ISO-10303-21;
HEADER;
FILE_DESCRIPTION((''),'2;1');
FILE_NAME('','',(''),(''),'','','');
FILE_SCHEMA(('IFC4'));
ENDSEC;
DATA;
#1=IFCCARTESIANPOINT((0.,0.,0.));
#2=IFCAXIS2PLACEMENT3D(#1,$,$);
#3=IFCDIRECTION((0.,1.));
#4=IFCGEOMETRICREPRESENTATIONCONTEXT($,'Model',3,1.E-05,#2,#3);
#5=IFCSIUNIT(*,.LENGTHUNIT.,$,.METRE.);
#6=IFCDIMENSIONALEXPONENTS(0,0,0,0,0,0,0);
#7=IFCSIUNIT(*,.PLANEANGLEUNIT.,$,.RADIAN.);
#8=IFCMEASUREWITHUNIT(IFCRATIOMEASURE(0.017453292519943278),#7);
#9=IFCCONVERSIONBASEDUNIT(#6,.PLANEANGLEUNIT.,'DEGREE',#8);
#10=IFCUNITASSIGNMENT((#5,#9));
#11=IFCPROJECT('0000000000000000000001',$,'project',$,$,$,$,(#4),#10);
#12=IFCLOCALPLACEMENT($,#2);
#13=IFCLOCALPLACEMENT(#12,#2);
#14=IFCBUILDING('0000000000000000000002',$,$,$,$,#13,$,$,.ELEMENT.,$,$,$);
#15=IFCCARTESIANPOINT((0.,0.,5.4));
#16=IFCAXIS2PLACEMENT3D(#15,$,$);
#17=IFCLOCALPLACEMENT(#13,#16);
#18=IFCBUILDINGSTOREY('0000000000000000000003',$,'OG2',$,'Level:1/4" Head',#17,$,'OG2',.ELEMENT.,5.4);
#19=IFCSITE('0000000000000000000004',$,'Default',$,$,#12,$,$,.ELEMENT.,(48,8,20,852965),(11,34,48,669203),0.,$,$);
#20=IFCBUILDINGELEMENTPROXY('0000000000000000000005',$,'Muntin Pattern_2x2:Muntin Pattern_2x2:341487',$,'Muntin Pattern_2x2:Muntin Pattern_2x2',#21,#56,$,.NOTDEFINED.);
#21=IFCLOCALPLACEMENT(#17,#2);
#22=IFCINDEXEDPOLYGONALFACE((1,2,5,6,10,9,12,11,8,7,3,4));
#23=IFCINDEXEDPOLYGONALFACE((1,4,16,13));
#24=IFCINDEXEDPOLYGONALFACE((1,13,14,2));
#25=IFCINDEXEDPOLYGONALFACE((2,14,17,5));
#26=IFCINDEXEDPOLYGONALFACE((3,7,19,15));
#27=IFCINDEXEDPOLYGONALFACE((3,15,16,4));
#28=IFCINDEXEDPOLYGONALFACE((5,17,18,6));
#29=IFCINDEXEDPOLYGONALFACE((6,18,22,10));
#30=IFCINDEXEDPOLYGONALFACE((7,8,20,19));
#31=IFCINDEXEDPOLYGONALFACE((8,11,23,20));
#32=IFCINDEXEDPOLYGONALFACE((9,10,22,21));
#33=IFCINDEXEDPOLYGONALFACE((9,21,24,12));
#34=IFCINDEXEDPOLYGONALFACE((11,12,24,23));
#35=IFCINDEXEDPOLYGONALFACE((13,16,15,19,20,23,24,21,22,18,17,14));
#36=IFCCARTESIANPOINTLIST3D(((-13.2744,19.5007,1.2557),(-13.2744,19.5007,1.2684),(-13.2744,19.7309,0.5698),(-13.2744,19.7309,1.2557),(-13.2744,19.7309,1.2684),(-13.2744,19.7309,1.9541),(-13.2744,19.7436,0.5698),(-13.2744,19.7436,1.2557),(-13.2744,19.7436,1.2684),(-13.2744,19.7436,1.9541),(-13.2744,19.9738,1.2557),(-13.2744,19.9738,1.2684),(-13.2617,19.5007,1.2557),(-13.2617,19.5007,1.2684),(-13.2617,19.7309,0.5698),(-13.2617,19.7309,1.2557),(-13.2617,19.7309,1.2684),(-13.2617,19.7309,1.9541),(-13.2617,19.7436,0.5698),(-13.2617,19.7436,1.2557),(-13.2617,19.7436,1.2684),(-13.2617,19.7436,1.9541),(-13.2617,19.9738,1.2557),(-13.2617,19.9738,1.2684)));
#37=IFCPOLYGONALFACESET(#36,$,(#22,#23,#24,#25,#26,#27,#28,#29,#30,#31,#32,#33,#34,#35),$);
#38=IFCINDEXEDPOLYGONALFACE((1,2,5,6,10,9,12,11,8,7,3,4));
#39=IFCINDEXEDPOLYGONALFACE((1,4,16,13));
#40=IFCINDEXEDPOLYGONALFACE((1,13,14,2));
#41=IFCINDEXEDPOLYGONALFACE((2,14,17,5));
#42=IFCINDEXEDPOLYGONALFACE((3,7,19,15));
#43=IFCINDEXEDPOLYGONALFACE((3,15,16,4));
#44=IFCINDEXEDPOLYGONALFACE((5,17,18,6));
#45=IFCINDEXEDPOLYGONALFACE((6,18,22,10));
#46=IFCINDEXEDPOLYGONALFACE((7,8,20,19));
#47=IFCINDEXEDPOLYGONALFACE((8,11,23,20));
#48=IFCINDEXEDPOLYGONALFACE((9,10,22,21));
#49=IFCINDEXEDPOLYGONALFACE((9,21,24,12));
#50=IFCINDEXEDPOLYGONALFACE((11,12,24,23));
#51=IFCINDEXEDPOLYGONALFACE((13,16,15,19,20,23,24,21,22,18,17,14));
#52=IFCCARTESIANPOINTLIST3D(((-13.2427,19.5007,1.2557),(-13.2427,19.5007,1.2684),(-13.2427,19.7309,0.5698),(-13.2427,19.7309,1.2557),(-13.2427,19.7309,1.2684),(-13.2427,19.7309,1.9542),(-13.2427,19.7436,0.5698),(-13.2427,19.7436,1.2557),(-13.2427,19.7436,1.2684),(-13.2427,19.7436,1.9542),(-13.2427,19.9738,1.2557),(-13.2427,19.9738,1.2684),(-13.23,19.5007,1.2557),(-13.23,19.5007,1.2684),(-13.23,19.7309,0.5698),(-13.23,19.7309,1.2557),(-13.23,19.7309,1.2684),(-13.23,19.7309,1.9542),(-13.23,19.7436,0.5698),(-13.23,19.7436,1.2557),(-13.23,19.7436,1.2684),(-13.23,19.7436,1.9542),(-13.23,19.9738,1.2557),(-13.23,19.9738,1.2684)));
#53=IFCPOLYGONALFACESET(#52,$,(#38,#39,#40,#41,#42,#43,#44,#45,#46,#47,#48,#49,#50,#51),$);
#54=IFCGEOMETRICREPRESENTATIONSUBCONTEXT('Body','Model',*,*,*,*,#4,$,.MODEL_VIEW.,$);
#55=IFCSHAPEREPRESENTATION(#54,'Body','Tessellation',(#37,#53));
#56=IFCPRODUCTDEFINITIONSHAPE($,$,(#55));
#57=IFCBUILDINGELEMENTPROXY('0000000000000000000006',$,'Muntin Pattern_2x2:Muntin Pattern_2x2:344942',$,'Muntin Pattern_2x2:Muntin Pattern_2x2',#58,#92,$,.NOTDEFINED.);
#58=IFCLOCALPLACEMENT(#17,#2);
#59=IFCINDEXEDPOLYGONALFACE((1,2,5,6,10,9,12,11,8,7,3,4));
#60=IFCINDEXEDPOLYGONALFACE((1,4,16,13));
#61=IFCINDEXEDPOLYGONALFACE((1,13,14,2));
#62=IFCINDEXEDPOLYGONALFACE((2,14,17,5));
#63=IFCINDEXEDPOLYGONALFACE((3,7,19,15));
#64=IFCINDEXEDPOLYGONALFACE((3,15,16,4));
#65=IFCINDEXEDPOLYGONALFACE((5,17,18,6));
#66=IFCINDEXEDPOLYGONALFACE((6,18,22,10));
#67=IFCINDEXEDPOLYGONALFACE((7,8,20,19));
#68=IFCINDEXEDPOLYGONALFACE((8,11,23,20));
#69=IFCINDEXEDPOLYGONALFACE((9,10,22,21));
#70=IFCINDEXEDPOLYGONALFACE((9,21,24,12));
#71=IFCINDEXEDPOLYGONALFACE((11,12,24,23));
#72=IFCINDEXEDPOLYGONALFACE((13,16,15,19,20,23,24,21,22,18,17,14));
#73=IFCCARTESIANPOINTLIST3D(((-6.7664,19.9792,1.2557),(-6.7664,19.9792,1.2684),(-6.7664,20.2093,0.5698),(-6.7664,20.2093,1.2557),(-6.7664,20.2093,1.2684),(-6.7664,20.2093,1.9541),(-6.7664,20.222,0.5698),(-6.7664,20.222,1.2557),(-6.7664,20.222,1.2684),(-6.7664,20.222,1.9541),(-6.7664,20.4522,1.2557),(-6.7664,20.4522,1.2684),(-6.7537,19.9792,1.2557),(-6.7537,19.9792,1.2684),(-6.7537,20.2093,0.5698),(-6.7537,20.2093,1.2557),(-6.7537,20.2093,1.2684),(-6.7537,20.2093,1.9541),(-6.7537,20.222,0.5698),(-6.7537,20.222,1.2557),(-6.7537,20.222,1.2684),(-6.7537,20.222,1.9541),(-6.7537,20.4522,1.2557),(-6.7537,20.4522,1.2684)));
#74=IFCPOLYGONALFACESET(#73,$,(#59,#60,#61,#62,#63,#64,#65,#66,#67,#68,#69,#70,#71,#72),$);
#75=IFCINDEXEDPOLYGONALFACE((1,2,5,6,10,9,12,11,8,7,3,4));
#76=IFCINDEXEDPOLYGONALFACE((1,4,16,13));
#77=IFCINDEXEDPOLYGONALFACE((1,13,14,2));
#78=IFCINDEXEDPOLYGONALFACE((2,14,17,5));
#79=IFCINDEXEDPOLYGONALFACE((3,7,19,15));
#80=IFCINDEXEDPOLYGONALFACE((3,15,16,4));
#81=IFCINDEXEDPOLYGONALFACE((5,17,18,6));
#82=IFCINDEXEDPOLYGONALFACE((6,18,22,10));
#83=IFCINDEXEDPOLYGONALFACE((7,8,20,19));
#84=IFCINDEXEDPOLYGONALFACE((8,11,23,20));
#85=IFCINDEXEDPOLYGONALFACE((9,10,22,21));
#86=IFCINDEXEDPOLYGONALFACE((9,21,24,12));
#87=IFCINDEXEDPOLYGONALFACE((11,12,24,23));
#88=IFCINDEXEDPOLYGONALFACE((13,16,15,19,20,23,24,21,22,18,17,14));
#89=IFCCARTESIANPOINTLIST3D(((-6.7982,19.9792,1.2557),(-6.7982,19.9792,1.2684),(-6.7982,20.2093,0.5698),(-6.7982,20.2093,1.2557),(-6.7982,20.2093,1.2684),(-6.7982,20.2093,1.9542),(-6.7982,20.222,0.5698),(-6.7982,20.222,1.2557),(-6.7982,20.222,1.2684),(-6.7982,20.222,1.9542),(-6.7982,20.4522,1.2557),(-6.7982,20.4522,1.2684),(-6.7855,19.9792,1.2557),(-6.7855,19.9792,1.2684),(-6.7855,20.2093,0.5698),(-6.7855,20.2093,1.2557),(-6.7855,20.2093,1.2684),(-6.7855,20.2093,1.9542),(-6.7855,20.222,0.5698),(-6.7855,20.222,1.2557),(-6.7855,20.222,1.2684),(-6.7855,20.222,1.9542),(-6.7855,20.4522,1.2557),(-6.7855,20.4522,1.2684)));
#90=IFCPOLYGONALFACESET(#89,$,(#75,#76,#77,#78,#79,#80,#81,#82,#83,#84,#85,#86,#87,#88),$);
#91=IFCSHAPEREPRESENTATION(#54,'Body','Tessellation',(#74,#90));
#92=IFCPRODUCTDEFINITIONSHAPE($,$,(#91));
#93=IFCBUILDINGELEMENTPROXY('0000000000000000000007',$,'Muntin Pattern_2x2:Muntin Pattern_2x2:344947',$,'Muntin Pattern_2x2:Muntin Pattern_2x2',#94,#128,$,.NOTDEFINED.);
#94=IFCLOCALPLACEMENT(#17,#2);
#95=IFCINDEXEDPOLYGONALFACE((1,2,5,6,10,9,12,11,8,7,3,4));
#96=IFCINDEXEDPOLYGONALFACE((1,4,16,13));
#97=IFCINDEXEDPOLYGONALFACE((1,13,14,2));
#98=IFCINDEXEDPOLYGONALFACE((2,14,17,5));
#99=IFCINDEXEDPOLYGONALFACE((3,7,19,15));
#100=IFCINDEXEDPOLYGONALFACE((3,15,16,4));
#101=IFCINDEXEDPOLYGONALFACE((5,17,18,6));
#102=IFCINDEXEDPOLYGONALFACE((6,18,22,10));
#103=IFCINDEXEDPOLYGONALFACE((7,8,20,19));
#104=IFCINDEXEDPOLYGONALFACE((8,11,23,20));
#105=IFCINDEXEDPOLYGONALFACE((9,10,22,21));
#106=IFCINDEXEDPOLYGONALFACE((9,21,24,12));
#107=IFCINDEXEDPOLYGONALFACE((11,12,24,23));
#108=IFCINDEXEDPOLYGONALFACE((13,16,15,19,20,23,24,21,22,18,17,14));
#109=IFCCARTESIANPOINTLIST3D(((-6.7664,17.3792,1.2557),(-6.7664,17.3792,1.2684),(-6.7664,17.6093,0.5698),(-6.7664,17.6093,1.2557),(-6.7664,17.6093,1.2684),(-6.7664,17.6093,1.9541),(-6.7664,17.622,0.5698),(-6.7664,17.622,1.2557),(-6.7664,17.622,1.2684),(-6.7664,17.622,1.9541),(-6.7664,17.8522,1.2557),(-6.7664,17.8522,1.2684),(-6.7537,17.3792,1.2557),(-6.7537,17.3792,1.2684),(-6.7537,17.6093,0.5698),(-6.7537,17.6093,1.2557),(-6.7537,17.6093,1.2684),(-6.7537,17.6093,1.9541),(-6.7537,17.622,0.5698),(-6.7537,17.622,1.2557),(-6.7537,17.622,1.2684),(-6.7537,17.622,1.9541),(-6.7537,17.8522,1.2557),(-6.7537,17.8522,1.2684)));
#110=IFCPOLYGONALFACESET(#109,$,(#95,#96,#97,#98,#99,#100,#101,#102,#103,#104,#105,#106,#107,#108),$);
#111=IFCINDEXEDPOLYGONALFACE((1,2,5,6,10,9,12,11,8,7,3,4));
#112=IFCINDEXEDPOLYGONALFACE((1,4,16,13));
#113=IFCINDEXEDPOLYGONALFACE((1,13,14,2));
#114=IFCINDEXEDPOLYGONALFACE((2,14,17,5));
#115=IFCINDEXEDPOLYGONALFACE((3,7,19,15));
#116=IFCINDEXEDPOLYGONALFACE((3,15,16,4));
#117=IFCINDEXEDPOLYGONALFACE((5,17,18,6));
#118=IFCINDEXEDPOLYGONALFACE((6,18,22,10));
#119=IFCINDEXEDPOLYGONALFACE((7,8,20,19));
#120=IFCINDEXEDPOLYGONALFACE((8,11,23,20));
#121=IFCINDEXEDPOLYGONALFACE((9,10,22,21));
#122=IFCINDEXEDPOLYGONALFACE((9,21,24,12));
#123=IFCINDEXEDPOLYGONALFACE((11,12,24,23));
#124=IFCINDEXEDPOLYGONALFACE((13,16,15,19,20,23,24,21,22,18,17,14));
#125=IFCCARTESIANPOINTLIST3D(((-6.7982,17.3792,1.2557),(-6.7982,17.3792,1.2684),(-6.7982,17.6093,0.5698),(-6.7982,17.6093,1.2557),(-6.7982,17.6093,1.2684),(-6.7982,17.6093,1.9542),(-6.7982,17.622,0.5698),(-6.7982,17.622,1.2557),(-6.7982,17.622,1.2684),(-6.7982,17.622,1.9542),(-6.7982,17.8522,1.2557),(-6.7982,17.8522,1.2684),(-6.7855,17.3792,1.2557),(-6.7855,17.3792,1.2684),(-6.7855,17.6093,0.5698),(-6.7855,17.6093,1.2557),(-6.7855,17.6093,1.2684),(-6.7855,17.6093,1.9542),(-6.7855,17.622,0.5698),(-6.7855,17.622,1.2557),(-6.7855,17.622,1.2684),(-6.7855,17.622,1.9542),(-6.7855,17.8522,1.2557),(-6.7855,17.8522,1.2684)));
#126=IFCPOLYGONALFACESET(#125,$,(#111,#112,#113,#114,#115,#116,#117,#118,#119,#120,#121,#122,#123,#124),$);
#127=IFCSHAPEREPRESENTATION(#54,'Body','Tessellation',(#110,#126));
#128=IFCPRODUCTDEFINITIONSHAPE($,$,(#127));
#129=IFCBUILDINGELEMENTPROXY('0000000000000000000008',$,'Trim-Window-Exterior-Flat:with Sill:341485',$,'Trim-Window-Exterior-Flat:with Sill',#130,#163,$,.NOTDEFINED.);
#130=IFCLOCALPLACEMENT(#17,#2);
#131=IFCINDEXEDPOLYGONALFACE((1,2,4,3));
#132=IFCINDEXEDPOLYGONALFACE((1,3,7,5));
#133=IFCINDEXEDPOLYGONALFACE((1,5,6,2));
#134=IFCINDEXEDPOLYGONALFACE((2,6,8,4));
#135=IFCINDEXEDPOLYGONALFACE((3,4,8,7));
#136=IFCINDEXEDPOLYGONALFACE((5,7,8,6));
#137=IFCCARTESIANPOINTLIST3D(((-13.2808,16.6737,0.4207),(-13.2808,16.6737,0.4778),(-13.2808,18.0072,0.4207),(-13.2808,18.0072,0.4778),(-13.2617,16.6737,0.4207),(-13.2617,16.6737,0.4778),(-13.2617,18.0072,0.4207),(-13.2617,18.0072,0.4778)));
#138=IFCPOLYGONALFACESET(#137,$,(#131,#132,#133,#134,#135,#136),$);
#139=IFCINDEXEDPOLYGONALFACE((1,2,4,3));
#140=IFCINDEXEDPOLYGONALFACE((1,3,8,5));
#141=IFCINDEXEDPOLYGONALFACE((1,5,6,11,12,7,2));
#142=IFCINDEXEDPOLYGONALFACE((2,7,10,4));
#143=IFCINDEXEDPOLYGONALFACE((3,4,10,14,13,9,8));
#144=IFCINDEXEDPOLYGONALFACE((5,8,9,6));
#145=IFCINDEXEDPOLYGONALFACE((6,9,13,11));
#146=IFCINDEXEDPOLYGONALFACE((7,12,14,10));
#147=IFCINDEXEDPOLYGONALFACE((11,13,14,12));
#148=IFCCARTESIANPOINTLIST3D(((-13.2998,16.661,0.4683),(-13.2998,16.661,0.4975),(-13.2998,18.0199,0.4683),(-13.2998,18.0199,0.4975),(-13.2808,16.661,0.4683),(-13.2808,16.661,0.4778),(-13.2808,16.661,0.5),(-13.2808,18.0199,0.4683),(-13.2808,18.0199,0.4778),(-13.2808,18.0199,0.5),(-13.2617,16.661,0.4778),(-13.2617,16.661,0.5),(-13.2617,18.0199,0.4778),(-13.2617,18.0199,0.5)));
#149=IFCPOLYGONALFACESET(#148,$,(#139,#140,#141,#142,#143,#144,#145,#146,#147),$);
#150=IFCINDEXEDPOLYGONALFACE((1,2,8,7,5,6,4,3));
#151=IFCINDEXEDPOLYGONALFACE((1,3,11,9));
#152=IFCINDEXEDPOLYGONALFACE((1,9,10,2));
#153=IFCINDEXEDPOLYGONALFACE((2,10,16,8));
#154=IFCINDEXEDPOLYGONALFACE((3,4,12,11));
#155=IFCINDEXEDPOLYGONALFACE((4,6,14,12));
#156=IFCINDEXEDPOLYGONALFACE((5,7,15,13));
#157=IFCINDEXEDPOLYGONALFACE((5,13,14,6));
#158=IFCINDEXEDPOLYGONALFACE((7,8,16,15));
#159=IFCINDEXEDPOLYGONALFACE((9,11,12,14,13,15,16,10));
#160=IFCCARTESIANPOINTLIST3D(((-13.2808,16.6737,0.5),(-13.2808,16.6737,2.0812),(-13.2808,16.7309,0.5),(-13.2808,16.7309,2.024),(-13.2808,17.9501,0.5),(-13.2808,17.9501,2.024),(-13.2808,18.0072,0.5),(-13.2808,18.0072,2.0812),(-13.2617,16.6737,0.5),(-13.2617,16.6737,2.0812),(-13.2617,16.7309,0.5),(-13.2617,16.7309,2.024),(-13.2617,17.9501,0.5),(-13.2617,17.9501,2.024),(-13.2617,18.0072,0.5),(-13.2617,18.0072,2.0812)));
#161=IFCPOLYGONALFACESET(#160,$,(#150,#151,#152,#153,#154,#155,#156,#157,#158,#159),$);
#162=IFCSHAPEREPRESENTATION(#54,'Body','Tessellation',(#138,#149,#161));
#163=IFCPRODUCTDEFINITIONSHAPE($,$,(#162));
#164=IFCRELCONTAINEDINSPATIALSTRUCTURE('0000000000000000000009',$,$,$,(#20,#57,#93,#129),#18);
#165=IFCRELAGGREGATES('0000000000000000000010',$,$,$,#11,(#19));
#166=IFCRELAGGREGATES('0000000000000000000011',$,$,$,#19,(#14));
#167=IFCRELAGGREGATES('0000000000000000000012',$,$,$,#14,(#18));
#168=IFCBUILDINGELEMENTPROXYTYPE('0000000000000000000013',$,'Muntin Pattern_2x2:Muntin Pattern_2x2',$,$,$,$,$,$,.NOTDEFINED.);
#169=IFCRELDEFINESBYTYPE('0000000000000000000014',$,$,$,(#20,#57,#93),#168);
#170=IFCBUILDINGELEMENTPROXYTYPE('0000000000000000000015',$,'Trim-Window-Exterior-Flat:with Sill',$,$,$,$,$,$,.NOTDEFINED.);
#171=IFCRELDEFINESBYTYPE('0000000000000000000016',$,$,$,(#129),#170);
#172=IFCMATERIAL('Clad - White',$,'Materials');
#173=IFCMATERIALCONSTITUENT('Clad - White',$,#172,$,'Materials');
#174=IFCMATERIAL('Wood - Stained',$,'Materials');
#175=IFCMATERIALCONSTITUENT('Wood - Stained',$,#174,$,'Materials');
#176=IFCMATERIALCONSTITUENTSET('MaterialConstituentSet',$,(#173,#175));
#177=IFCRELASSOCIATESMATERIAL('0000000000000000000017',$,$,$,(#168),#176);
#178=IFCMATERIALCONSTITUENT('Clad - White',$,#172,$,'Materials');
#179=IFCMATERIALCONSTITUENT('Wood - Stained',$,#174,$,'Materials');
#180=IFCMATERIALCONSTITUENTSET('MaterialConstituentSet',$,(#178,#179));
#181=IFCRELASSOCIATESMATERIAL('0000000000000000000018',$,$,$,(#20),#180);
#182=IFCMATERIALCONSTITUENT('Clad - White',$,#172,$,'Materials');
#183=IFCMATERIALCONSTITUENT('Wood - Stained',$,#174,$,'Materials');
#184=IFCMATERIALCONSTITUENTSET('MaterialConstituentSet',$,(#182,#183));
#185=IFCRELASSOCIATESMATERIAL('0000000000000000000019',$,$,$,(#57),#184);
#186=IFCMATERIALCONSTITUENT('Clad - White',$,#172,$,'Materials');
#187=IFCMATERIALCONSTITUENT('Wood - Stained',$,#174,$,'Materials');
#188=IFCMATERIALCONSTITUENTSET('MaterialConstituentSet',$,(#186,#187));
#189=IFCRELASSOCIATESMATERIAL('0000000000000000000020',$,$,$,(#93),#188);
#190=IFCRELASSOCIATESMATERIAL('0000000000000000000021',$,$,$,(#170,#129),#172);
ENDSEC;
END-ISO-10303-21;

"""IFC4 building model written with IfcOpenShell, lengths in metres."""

from ifc_helpers import new_model, entity, si_unit, converted_unit, direction, frame, origin, place, context, subcontext, project, spatial, indexed_curve, outline, extrude, source, transform, mapped, material, constituent, constituent_set, type_object, type_shapes, element, save


model = new_model("IFC4")

# Units and contexts
model_context = context("Model", 3, precision=1e-05, world=origin(), true_north=direction((0.0, 1.0)))
body_context = subcontext(model_context, "Body", "Model", "MODEL_VIEW")
ifc_project = project(units=[si_unit("LENGTHUNIT", "METRE"), converted_unit("PLANEANGLEUNIT", "DEGREE", entity("IfcRatioMeasure", 0.017453292519943278), si_unit("PLANEANGLEUNIT", "RADIAN"), dimensions=[0, 0, 0, 0, 0, 0, 0])], contexts=[model_context])

# Site, building, storey
site_placement = place(None, origin())
site = spatial("IfcSite", under=ifc_project, at=site_placement, Name="Default", CompositionType="ELEMENT", RefLatitude=(48, 8, 20, 852965), RefLongitude=(11, 34, 48, 669203), RefElevation=0.0)
building_placement = place(site_placement, origin())
building = spatial("IfcBuilding", under=site, at=building_placement, CompositionType="ELEMENT")
storey_placement = place(building_placement, frame((0.0, 0.0, 5.4)))
storey = spatial("IfcBuildingStorey", under=building, at=storey_placement, Name="OG2", ObjectType="Level:1/4\" Head", LongName="OG2", CompositionType="ELEMENT", Elevation=5.4)

# Building element proxies
ifc_material_1 = material(Name="Clad - White", Category="Materials")
ifc_material_2 = material(Name="Wood - Stained", Category="Materials")
ifc_constituent_1 = constituent(ifc_material_1, Name="Clad - White", Category="Materials")
ifc_constituent_2 = constituent(ifc_material_2, Name="Wood - Stained", Category="Materials")
ifc_constituent_set_1 = constituent_set(constituents=[ifc_constituent_1, ifc_constituent_2], Name="MaterialConstituentSet")
building_element_proxy_type_1 = type_object("IfcBuildingElementProxyType", Name="Muntin Pattern_2x2:Muntin Pattern_2x2", PredefinedType="NOTDEFINED", material=ifc_constituent_set_1)
shared_shape_1 = source(origin(), body_context, "Body", "SweptSolid", [
    extrude(outline(indexed_curve([(0.0064, -0.0064), (0.6921, -0.0064), (0.6921, 0.0063), (0.0064, 0.0063), (0.0064, 0.2365), (-0.0063, 0.2365), (-0.0063, 0.0063), (-0.6922, 0.0063), (-0.6922, -0.0064), (-0.0063, -0.0064), (-0.0063, -0.2365), (0.0064, -0.2365), (0.0064, -0.0064)], self_intersect=False)), frame((0.0, 0.0095, 0.6921), z_axis=(0.0, 1.0, 0.0), x_axis=(0.0, 0.0, 1.0)), (0.0, 0.0, 1.0), 0.0127),
    extrude(outline(indexed_curve([(0.0064, -0.0064), (0.6922, -0.0064), (0.6922, 0.0063), (0.0064, 0.0063), (0.0064, 0.2365), (-0.0063, 0.2365), (-0.0063, 0.0063), (-0.6922, 0.0063), (-0.6922, -0.0064), (-0.0063, -0.0064), (-0.0063, -0.2365), (0.0064, -0.2365), (0.0064, -0.0064)], self_intersect=False)), frame((0.0, -0.0222, 0.6922), z_axis=(0.0, 1.0, 0.0), x_axis=(0.0, 0.0, 1.0)), (0.0, 0.0, 1.0), 0.0127),
])
type_shapes(building_element_proxy_type_1, [shared_shape_1])
ifc_constituent_3 = constituent(ifc_material_1, Name="Clad - White", Category="Materials")
ifc_constituent_4 = constituent(ifc_material_2, Name="Wood - Stained", Category="Materials")
ifc_constituent_set_2 = constituent_set(constituents=[ifc_constituent_3, ifc_constituent_4], Name="MaterialConstituentSet")
proxy_1_placement = place(storey_placement, frame((-13.2522, 19.7372, 0.5699), z_axis=(0.0, 0.0, 1.0), x_axis=(0.0, 1.0, 0.0)))
element("IfcBuildingElementProxy", 1, at=proxy_1_placement, inside=storey, type_object=building_element_proxy_type_1, material=ifc_constituent_set_2, Name="Muntin Pattern_2x2:Muntin Pattern_2x2:341487", ObjectType="Muntin Pattern_2x2:Muntin Pattern_2x2", PredefinedType="NOTDEFINED", context=body_context, shape_type="MappedRepresentation", body=[
    mapped(shared_shape_1, transform((0.0, 0.0, 0.0), scale=1.0)),
])
ifc_constituent_5 = constituent(ifc_material_1, Name="Clad - White", Category="Materials")
ifc_constituent_6 = constituent(ifc_material_2, Name="Wood - Stained", Category="Materials")
ifc_constituent_set_3 = constituent_set(constituents=[ifc_constituent_5, ifc_constituent_6], Name="MaterialConstituentSet")
proxy_2_placement = place(storey_placement, frame((-6.7759, 20.2157, 0.5699), z_axis=(0.0, 0.0, 1.0), x_axis=(0.0, -1.0, 0.0)))
element("IfcBuildingElementProxy", 2, at=proxy_2_placement, inside=storey, type_object=building_element_proxy_type_1, material=ifc_constituent_set_3, Name="Muntin Pattern_2x2:Muntin Pattern_2x2:344942", ObjectType="Muntin Pattern_2x2:Muntin Pattern_2x2", PredefinedType="NOTDEFINED", context=body_context, shape_type="MappedRepresentation", body=[
    mapped(shared_shape_1, transform((0.0, 0.0, 0.0), scale=1.0)),
])
ifc_constituent_7 = constituent(ifc_material_1, Name="Clad - White", Category="Materials")
ifc_constituent_8 = constituent(ifc_material_2, Name="Wood - Stained", Category="Materials")
ifc_constituent_set_4 = constituent_set(constituents=[ifc_constituent_7, ifc_constituent_8], Name="MaterialConstituentSet")
proxy_3_placement = place(storey_placement, frame((-6.7759, 17.6157, 0.5699), z_axis=(0.0, 0.0, 1.0), x_axis=(0.0, -1.0, 0.0)))
element("IfcBuildingElementProxy", 3, at=proxy_3_placement, inside=storey, type_object=building_element_proxy_type_1, material=ifc_constituent_set_4, Name="Muntin Pattern_2x2:Muntin Pattern_2x2:344947", ObjectType="Muntin Pattern_2x2:Muntin Pattern_2x2", PredefinedType="NOTDEFINED", context=body_context, shape_type="MappedRepresentation", body=[
    mapped(shared_shape_1, transform((0.0, 0.0, 0.0), scale=1.0)),
])
building_element_proxy_type_2 = type_object("IfcBuildingElementProxyType", Name="Trim-Window-Exterior-Flat:with Sill", PredefinedType="NOTDEFINED", material=ifc_material_1)
shared_shape_2 = source(origin(), body_context, "Body", "SweptSolid", [
    extrude(outline(indexed_curve([(-0.6667, -0.0286), (0.6667, -0.0286), (0.6667, 0.0286), (-0.6667, 0.0286), (-0.6667, -0.0286)], self_intersect=False)), frame((0.0, -1.5748, 0.0), z_axis=(0.0, 0.0, 1.0), x_axis=(-1.0, 0.0, 0.0)), (0.0, 0.0, 1.0), 0.019),
    extrude(outline(indexed_curve([(-0.019, -0.016), (0.0, -0.016), (0.0, -0.0064), (0.019, -0.0064), (0.019, 0.0158), (0.0, 0.0158), (-0.019, 0.0133), (-0.019, -0.016)], self_intersect=False)), frame((-0.6794, -1.5398, 0.019), z_axis=(1.0, 0.0, 0.0), x_axis=(0.0, 0.0, -1.0)), (0.0, 0.0, 1.0), 1.3589),
    extrude(outline(indexed_curve([(-0.8049, -0.6667), (0.7763, -0.6667), (0.7763, -0.6096), (-0.7477, -0.6096), (-0.7477, 0.6096), (0.7763, 0.6096), (0.7763, 0.6667), (-0.8049, 0.6667), (-0.8049, -0.6667)], self_intersect=False)), frame((0.0, -0.7477, 0.0), z_axis=(0.0, 0.0, 1.0), x_axis=(0.0, -1.0, 0.0)), (0.0, 0.0, 1.0), 0.019),
])
type_shapes(building_element_proxy_type_2, [shared_shape_2])
for number, where, z_axis, x_axis, name in (
    (4, (-13.2617, 17.3405, 2.024), (-1.0, 0.0, 0.0), (0.0, -1.0, 0.0), "Trim-Window-Exterior-Flat:with Sill:341485"),
):
    element("IfcBuildingElementProxy", number, at=place(storey_placement, frame(where, z_axis=z_axis, x_axis=x_axis)), inside=storey, type_object=building_element_proxy_type_2, material=ifc_material_1, Name=name, ObjectType="Trim-Window-Exterior-Flat:with Sill", PredefinedType="NOTDEFINED", context=body_context, shape_type="MappedRepresentation", body=[
        mapped(shared_shape_2, transform((0.0, 0.0, 0.0), scale=1.0)),
    ])

save(model, "model.ifc")
